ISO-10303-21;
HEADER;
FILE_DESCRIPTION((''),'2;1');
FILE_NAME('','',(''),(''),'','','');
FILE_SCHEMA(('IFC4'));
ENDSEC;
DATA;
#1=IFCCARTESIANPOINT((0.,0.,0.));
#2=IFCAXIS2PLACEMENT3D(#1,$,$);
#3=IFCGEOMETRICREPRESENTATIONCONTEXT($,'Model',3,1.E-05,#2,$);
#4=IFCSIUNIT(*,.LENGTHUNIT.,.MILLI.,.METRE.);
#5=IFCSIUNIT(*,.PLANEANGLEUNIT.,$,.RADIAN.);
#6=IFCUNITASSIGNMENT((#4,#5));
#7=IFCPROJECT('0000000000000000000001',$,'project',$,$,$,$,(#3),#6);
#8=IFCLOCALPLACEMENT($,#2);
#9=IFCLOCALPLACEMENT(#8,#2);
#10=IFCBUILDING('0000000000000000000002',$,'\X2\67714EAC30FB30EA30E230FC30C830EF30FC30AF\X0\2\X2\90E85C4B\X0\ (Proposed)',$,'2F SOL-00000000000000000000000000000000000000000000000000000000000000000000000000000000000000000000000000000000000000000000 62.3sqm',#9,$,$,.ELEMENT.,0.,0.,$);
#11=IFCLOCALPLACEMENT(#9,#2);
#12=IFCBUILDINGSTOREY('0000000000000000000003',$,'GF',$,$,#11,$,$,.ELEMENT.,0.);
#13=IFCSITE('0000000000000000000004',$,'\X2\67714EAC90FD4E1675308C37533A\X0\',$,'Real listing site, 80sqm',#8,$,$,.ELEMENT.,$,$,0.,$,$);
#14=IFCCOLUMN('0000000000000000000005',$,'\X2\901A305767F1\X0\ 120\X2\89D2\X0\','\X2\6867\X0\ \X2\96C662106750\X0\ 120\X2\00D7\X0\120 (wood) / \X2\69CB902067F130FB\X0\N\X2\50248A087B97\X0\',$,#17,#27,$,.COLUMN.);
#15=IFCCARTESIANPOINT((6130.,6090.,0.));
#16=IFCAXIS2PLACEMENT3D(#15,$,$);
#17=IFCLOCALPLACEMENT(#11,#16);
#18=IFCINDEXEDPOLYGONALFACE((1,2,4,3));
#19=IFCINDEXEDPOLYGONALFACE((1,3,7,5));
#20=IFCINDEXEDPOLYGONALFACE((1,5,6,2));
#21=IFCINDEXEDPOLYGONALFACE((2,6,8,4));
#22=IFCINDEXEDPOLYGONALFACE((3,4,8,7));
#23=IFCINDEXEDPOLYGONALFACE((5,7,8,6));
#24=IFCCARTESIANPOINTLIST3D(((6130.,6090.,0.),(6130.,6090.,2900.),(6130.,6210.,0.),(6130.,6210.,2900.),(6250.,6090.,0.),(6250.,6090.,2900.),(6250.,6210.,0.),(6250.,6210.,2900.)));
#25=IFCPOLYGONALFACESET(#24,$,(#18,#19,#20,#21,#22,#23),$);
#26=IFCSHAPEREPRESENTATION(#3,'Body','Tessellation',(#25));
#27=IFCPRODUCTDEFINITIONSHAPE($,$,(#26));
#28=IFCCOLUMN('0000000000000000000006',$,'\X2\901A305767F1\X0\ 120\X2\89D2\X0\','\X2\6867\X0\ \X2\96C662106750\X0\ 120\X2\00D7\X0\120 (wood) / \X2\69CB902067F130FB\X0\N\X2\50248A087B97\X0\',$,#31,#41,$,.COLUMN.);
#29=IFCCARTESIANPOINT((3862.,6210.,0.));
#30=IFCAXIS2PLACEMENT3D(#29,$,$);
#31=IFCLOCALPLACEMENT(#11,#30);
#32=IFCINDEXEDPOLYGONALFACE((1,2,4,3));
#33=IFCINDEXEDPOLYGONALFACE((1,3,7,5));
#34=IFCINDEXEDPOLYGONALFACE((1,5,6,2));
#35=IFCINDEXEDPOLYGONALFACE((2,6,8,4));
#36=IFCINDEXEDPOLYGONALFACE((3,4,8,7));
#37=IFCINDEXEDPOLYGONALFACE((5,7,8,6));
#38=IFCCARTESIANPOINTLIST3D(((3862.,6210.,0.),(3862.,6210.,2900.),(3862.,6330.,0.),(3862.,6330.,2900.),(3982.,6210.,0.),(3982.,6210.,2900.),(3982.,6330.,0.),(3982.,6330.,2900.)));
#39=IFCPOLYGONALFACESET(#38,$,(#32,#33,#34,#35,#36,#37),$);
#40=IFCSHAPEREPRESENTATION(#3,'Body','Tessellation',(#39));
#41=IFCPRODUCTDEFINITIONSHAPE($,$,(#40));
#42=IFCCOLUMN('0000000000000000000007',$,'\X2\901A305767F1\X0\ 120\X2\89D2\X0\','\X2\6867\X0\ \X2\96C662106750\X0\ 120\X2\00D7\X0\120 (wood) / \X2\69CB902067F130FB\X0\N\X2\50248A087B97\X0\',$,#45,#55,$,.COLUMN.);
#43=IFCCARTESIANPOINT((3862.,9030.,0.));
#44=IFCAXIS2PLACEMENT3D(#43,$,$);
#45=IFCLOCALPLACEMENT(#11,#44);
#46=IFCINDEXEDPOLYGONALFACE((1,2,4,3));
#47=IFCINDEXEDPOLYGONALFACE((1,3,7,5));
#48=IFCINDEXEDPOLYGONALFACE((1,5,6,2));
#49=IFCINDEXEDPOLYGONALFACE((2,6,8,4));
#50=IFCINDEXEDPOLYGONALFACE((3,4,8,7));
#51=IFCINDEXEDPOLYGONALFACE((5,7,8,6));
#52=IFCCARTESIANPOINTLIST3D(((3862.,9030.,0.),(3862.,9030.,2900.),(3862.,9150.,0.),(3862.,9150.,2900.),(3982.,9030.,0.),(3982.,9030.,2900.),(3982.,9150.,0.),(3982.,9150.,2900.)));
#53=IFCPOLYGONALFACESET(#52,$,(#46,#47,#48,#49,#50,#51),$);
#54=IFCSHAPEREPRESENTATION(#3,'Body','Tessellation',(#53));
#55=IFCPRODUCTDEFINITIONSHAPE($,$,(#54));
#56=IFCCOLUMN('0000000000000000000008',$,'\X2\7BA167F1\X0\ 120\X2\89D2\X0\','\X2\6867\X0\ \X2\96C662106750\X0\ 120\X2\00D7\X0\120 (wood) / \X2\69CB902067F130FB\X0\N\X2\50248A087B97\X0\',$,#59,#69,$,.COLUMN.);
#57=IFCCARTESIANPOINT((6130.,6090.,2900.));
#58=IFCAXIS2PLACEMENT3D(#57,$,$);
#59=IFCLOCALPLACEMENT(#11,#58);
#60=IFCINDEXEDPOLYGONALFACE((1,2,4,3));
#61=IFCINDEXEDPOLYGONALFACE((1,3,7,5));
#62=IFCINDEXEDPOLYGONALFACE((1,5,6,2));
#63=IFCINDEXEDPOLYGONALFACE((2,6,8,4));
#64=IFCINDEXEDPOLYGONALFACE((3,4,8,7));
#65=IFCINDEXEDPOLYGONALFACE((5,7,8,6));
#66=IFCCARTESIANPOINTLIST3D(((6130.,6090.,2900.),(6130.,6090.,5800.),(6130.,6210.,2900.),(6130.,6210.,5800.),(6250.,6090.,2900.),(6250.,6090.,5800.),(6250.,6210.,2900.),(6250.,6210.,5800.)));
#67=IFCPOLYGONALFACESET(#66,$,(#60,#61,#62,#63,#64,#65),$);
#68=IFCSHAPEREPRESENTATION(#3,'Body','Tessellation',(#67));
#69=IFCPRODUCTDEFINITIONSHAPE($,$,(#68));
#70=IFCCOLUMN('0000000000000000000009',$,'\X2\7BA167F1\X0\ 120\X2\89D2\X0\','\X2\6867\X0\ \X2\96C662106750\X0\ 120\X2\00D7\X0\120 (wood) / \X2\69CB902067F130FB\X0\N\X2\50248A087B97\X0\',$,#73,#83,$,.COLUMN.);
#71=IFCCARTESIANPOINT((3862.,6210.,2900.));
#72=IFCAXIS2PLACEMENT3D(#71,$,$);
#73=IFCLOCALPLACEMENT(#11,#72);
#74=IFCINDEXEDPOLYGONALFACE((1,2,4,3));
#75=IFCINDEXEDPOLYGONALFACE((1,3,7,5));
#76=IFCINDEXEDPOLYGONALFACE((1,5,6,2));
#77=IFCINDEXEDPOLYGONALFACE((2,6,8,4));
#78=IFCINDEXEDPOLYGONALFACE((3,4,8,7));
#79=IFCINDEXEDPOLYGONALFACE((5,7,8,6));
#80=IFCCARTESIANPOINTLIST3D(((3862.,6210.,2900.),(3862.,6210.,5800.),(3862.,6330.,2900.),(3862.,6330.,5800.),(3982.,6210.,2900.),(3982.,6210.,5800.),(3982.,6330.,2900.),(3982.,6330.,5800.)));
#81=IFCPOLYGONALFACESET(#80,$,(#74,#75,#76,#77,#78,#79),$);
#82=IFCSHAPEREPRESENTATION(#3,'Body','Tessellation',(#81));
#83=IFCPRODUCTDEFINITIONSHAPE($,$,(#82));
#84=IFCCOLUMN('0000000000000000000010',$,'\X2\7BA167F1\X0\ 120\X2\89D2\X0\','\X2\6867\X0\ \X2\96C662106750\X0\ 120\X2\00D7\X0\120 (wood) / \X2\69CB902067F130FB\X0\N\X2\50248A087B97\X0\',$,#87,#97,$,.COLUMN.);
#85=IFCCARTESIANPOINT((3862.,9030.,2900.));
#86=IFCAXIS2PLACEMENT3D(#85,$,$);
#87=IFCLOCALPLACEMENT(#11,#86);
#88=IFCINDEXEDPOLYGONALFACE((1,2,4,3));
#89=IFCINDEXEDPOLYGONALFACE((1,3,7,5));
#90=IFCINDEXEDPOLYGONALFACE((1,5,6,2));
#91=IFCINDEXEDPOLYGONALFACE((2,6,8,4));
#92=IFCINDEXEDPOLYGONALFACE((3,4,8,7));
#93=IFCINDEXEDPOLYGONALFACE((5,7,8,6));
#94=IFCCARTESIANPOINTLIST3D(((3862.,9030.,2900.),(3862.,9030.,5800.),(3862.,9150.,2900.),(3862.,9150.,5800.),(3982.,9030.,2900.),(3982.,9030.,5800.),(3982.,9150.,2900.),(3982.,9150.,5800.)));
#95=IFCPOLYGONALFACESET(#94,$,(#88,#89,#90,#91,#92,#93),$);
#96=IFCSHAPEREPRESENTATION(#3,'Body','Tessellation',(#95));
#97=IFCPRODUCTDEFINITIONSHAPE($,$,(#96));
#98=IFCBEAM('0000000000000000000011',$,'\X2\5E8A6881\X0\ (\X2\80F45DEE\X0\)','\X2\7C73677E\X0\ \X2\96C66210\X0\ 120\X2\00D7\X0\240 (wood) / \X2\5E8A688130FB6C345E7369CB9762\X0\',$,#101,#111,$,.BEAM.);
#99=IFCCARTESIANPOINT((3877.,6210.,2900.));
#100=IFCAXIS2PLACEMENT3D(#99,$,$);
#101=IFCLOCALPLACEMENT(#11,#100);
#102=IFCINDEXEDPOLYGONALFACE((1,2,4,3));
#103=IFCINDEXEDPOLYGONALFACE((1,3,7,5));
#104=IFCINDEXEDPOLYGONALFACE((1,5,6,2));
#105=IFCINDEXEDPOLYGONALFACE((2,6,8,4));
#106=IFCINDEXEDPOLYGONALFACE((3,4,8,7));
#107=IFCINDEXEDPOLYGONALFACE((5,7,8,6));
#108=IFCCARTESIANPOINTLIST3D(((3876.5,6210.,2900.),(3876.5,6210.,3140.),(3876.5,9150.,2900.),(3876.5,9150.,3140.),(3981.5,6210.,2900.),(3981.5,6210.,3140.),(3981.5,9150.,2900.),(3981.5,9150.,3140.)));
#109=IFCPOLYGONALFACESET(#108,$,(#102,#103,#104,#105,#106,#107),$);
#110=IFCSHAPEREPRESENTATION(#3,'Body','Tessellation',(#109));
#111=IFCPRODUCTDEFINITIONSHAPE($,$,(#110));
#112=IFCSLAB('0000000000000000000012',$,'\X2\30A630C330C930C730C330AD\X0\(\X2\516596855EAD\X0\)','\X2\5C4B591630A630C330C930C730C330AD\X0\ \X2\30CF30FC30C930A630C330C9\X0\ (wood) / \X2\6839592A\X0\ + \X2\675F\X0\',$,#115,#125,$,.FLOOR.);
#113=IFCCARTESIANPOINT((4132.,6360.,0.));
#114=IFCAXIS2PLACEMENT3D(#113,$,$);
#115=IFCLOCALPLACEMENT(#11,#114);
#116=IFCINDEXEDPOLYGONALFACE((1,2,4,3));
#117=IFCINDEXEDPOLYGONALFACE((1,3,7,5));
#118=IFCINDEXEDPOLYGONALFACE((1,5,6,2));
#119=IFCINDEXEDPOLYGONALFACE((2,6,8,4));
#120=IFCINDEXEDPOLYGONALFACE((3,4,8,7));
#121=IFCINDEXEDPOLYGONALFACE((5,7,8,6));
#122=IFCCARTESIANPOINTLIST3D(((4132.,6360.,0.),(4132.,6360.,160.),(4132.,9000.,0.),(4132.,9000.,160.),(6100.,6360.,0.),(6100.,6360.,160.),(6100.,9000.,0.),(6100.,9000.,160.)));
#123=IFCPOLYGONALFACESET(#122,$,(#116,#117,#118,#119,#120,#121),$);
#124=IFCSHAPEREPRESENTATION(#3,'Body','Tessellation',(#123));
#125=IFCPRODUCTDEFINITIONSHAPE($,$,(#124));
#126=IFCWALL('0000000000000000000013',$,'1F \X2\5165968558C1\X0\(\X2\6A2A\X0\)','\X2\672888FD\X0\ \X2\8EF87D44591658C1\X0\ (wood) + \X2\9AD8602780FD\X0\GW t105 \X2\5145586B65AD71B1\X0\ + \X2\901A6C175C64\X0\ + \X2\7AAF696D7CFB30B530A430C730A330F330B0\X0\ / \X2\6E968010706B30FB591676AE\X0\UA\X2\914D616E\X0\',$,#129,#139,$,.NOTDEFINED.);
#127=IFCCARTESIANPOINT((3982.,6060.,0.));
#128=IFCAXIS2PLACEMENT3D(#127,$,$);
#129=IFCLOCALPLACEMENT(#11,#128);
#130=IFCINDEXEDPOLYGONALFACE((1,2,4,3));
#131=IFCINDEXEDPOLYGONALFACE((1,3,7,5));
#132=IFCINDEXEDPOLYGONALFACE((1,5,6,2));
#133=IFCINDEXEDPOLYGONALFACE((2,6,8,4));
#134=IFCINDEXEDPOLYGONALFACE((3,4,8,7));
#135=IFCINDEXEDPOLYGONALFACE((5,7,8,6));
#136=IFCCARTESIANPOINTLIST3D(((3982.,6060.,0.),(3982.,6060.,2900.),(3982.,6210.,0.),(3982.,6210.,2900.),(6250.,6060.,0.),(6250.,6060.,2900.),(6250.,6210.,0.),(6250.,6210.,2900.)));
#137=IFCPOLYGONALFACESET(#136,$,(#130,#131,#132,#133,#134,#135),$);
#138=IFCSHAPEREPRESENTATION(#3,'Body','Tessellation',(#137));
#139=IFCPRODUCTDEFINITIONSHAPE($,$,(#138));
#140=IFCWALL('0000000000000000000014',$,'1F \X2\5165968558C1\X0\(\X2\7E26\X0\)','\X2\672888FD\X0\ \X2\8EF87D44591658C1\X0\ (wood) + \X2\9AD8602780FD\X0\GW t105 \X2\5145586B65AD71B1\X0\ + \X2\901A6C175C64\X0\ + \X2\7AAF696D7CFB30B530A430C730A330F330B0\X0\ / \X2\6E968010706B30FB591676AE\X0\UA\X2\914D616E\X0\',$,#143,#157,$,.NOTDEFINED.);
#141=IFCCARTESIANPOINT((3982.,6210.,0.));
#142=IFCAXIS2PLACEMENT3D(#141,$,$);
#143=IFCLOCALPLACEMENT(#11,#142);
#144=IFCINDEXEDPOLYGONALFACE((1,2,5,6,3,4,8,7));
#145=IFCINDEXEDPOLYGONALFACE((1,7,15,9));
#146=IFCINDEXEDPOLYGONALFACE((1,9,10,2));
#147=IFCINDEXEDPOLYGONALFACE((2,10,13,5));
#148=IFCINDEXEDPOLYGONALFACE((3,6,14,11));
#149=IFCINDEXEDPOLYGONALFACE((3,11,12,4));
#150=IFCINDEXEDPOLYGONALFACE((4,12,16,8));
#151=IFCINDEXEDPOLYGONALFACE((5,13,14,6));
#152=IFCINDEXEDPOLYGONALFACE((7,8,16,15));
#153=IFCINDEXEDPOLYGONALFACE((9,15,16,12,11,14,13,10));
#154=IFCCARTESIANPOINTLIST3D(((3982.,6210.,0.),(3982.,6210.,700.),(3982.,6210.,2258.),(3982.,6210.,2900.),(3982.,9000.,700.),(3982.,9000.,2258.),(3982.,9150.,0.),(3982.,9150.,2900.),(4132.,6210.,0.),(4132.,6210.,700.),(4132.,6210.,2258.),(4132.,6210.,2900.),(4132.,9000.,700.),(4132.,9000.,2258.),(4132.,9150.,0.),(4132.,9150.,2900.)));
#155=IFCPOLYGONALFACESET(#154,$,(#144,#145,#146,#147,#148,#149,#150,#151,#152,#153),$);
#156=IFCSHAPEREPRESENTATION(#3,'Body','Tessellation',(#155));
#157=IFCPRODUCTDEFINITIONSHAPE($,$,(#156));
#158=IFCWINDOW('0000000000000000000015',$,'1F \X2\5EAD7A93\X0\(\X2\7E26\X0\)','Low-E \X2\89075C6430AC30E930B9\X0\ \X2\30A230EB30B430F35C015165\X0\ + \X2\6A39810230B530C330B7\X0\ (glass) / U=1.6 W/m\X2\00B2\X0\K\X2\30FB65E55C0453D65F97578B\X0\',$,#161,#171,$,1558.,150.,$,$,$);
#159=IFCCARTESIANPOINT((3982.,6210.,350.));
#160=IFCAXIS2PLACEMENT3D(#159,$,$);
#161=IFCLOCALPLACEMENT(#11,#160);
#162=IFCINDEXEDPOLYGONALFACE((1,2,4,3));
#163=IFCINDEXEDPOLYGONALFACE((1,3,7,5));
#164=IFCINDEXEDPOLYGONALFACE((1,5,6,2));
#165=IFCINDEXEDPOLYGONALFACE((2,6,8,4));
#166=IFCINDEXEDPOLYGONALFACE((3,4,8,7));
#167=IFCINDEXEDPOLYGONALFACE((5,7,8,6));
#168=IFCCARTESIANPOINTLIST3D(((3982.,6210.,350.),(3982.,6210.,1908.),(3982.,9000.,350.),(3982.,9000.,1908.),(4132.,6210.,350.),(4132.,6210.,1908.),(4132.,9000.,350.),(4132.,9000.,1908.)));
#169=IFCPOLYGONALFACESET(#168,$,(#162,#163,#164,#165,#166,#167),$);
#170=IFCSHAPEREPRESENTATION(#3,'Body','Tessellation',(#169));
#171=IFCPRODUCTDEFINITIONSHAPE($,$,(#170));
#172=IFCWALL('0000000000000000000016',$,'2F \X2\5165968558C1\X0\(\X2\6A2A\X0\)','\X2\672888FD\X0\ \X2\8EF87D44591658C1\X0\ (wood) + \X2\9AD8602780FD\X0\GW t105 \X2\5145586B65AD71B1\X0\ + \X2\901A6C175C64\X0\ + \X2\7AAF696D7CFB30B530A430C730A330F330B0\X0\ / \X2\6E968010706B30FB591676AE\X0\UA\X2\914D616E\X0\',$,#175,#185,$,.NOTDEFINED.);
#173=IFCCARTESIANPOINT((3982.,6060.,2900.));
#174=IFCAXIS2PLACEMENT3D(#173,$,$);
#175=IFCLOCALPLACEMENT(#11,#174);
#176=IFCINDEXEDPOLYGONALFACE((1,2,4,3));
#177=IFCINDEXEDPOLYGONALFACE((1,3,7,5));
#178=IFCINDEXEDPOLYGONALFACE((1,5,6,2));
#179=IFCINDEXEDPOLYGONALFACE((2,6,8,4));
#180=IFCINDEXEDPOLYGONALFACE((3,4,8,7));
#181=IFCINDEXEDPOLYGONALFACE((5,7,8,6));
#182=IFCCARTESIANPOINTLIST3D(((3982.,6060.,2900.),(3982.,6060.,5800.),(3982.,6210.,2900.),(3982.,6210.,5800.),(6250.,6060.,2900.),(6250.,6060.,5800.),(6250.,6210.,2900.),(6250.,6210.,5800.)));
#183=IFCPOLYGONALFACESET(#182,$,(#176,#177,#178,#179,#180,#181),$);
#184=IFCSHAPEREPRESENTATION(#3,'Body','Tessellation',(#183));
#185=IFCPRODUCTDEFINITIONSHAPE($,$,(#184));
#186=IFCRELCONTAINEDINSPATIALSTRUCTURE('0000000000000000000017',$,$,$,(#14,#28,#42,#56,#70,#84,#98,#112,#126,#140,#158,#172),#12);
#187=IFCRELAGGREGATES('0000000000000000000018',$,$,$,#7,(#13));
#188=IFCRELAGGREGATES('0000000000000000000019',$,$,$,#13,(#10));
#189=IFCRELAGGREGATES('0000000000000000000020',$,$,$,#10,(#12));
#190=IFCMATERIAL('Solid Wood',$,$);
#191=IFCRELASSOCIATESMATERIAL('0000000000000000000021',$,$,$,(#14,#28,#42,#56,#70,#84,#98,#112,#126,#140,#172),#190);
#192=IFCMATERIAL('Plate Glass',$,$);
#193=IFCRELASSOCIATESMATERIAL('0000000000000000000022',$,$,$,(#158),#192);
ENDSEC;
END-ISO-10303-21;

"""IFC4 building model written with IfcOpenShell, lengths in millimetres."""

from ifc_helpers import new_model, si_unit, frame, frame_2d, origin, place, context, project, spatial, rectangle, extrude, material, element, fill, save


model = new_model("IFC4")

# Units and contexts
model_context = context("Model", 3, precision=1e-05, world=origin())
ifc_project = project(units=[si_unit("LENGTHUNIT", "METRE", prefix="MILLI"), si_unit("PLANEANGLEUNIT", "RADIAN")], contexts=[model_context])

# Site, building, storey
site_placement = place(None, origin())
site = spatial("IfcSite", under=ifc_project, at=site_placement, Name="東京都世田谷区", ObjectType="Real listing site, 80sqm", CompositionType="ELEMENT", RefElevation=0.0)
building_placement = place(site_placement, origin())
building = spatial("IfcBuilding", under=site, at=building_placement, Name="東京・リモートワーク2部屋 (Proposed)", ObjectType="2F SOL-00000000000000000000000000000000000000000000000000000000000000000000000000000000000000000000000000000000000000000000 62.3sqm", CompositionType="ELEMENT", ElevationOfRefHeight=0.0, ElevationOfTerrain=0.0)
storey_placement = place(building_placement, origin())
storey = spatial("IfcBuildingStorey", under=building, at=storey_placement, Name="GF", CompositionType="ELEMENT", Elevation=0.0)

# Columns
ifc_material_1 = material(Name="Solid Wood")
column_1_placement = place(storey_placement, frame((6130.0, 6090.0, 0.0)))
element("IfcColumn", 1, at=column_1_placement, inside=storey, material=ifc_material_1, Name="通し柱 120角", Description="桧 集成材 120×120 (wood) / 構造柱・N値計算", PredefinedType="COLUMN", context=model_context, shape_type="SweptSolid", body=[
    extrude(rectangle(XDim=120.0, YDim=120.0, at=frame_2d((60.0, 60.0))), frame((6130.0, 6090.0, 0.0)), (0.0, 0.0, 1.0), 2900.0),
])
column_2_placement = place(storey_placement, frame((3862.0, 6210.0, 0.0)))
element("IfcColumn", 2, at=column_2_placement, inside=storey, material=ifc_material_1, Name="通し柱 120角", Description="桧 集成材 120×120 (wood) / 構造柱・N値計算", PredefinedType="COLUMN", context=model_context, shape_type="SweptSolid", body=[
    extrude(rectangle(XDim=120.0, YDim=120.0, at=frame_2d((60.0, 60.0))), frame((3862.0, 6210.0, 0.0)), (0.0, 0.0, 1.0), 2900.0),
])
column_3_placement = place(storey_placement, frame((3862.0, 9030.0, 0.0)))
element("IfcColumn", 3, at=column_3_placement, inside=storey, material=ifc_material_1, Name="通し柱 120角", Description="桧 集成材 120×120 (wood) / 構造柱・N値計算", PredefinedType="COLUMN", context=model_context, shape_type="SweptSolid", body=[
    extrude(rectangle(XDim=120.0, YDim=120.0, at=frame_2d((60.0, 60.0))), frame((3862.0, 9030.0, 0.0)), (0.0, 0.0, 1.0), 2900.0),
])
column_4_placement = place(storey_placement, frame((6130.0, 6090.0, 2900.0)))
element("IfcColumn", 4, at=column_4_placement, inside=storey, material=ifc_material_1, Name="管柱 120角", Description="桧 集成材 120×120 (wood) / 構造柱・N値計算", PredefinedType="COLUMN", context=model_context, shape_type="SweptSolid", body=[
    extrude(rectangle(XDim=120.0, YDim=120.0, at=frame_2d((60.0, 60.0))), frame((6130.0, 6090.0, 2900.0)), (0.0, 0.0, 1.0), 2900.0),
])
column_5_placement = place(storey_placement, frame((3862.0, 6210.0, 2900.0)))
element("IfcColumn", 5, at=column_5_placement, inside=storey, material=ifc_material_1, Name="管柱 120角", Description="桧 集成材 120×120 (wood) / 構造柱・N値計算", PredefinedType="COLUMN", context=model_context, shape_type="SweptSolid", body=[
    extrude(rectangle(XDim=120.0, YDim=120.0, at=frame_2d((60.0, 60.0))), frame((3862.0, 6210.0, 2900.0)), (0.0, 0.0, 1.0), 2900.0),
])
column_6_placement = place(storey_placement, frame((3862.0, 9030.0, 2900.0)))
element("IfcColumn", 6, at=column_6_placement, inside=storey, material=ifc_material_1, Name="管柱 120角", Description="桧 集成材 120×120 (wood) / 構造柱・N値計算", PredefinedType="COLUMN", context=model_context, shape_type="SweptSolid", body=[
    extrude(rectangle(XDim=120.0, YDim=120.0, at=frame_2d((60.0, 60.0))), frame((3862.0, 9030.0, 2900.0)), (0.0, 0.0, 1.0), 2900.0),
])

# Beam
beam_1_placement = place(storey_placement, frame((3877.0, 6210.0, 2900.0)))
element("IfcBeam", 7, at=beam_1_placement, inside=storey, material=ifc_material_1, Name="床梁 (胴差)", Description="米松 集成 120×240 (wood) / 床梁・水平構面", PredefinedType="BEAM", context=model_context, shape_type="SweptSolid", body=[
    extrude(rectangle(XDim=105.0, YDim=2940.0, at=frame_2d((52.0, 1470.0))), frame((3877.0, 6210.0, 2900.0)), (0.0, 0.0, 1.0), 240.0),
])

# Slab
slab_placement = place(storey_placement, frame((4132.0, 6360.0, 0.0)))
element("IfcSlab", 8, at=slab_placement, inside=storey, material=ifc_material_1, Name="ウッドデッキ(入隅庭)", Description="屋外ウッドデッキ ハードウッド (wood) / 根太 + 束", PredefinedType="FLOOR", context=model_context, shape_type="SweptSolid", body=[
    extrude(rectangle(XDim=1968.0, YDim=2640.0, at=frame_2d((984.0, 1320.0))), frame((4132.0, 6360.0, 0.0)), (0.0, 0.0, 1.0), 160.0),
])

# Wall
wall_1_placement = place(storey_placement, frame((3982.0, 6060.0, 0.0)))
element("IfcWall", 9, at=wall_1_placement, inside=storey, material=ifc_material_1, Name="1F 入隅壁(横)", Description="木製 軸組外壁 (wood) + 高性能GW t105 充填断熱 + 通気層 + 窯業系サイディング / 準耐火・外皮UA配慮", PredefinedType="NOTDEFINED", context=model_context, shape_type="SweptSolid", body=[
    extrude(rectangle(XDim=2268.0, YDim=150.0, at=frame_2d((1134.0, 75.0))), frame((3982.0, 6060.0, 0.0)), (0.0, 0.0, 1.0), 2900.0),
])

# Wall, opening, window
wall_2_placement = place(storey_placement, frame((3982.0, 6210.0, 0.0)))
wall_2 = element("IfcWall", 10, at=wall_2_placement, inside=storey, material=ifc_material_1, Name="1F 入隅壁(縦)", Description="木製 軸組外壁 (wood) + 高性能GW t105 充填断熱 + 通気層 + 窯業系サイディング / 準耐火・外皮UA配慮", PredefinedType="NOTDEFINED", context=model_context, shape_type="SweptSolid", body=[
    extrude(rectangle(XDim=150.0, YDim=2940.0, at=frame_2d((75.0, 1470.0))), frame((3982.0, 6210.0, 0.0)), (0.0, 0.0, 1.0), 2900.0),
])
opening_1_placement = place(storey_placement, frame((3982.0, 6210.0, 350.0)))
opening_1 = element("IfcOpeningElement", 11, at=opening_1_placement, cuts=wall_2, PredefinedType="NOTDEFINED", context=model_context, shape_type="SweptSolid", body=[
    extrude(rectangle(XDim=150.0, YDim=2790.0, at=frame_2d((75.0, 1395.0))), frame((3982.0, 6210.0, 350.0)), (0.0, 0.0, 1.0), 1558.0),
])
ifc_material_2 = material(Name="Plate Glass")
window_1_placement = place(storey_placement, frame((3982.0, 6210.0, 350.0)))
window_1 = element("IfcWindow", 12, at=window_1_placement, inside=storey, material=ifc_material_2, Name="1F 庭窓(縦)", Description="Low-E 複層ガラス アルゴン封入 + 樹脂サッシ (glass) / U=1.6 W/m²K・日射取得型", OverallHeight=1558.0, OverallWidth=150.0, context=model_context, shape_type="SweptSolid", body=[
    extrude(rectangle(XDim=150.0, YDim=2790.0, at=frame_2d((75.0, 1395.0))), frame((3982.0, 6210.0, 350.0)), (0.0, 0.0, 1.0), 1558.0),
])
fill(opening_1, window_1)

# Wall
wall_3_placement = place(storey_placement, frame((3982.0, 6060.0, 2900.0)))
element("IfcWall", 13, at=wall_3_placement, inside=storey, material=ifc_material_1, Name="2F 入隅壁(横)", Description="木製 軸組外壁 (wood) + 高性能GW t105 充填断熱 + 通気層 + 窯業系サイディング / 準耐火・外皮UA配慮", PredefinedType="NOTDEFINED", context=model_context, shape_type="SweptSolid", body=[
    extrude(rectangle(XDim=2268.0, YDim=150.0, at=frame_2d((1134.0, 75.0))), frame((3982.0, 6060.0, 2900.0)), (0.0, 0.0, 1.0), 2900.0),
])

save(model, "model.ifc")
